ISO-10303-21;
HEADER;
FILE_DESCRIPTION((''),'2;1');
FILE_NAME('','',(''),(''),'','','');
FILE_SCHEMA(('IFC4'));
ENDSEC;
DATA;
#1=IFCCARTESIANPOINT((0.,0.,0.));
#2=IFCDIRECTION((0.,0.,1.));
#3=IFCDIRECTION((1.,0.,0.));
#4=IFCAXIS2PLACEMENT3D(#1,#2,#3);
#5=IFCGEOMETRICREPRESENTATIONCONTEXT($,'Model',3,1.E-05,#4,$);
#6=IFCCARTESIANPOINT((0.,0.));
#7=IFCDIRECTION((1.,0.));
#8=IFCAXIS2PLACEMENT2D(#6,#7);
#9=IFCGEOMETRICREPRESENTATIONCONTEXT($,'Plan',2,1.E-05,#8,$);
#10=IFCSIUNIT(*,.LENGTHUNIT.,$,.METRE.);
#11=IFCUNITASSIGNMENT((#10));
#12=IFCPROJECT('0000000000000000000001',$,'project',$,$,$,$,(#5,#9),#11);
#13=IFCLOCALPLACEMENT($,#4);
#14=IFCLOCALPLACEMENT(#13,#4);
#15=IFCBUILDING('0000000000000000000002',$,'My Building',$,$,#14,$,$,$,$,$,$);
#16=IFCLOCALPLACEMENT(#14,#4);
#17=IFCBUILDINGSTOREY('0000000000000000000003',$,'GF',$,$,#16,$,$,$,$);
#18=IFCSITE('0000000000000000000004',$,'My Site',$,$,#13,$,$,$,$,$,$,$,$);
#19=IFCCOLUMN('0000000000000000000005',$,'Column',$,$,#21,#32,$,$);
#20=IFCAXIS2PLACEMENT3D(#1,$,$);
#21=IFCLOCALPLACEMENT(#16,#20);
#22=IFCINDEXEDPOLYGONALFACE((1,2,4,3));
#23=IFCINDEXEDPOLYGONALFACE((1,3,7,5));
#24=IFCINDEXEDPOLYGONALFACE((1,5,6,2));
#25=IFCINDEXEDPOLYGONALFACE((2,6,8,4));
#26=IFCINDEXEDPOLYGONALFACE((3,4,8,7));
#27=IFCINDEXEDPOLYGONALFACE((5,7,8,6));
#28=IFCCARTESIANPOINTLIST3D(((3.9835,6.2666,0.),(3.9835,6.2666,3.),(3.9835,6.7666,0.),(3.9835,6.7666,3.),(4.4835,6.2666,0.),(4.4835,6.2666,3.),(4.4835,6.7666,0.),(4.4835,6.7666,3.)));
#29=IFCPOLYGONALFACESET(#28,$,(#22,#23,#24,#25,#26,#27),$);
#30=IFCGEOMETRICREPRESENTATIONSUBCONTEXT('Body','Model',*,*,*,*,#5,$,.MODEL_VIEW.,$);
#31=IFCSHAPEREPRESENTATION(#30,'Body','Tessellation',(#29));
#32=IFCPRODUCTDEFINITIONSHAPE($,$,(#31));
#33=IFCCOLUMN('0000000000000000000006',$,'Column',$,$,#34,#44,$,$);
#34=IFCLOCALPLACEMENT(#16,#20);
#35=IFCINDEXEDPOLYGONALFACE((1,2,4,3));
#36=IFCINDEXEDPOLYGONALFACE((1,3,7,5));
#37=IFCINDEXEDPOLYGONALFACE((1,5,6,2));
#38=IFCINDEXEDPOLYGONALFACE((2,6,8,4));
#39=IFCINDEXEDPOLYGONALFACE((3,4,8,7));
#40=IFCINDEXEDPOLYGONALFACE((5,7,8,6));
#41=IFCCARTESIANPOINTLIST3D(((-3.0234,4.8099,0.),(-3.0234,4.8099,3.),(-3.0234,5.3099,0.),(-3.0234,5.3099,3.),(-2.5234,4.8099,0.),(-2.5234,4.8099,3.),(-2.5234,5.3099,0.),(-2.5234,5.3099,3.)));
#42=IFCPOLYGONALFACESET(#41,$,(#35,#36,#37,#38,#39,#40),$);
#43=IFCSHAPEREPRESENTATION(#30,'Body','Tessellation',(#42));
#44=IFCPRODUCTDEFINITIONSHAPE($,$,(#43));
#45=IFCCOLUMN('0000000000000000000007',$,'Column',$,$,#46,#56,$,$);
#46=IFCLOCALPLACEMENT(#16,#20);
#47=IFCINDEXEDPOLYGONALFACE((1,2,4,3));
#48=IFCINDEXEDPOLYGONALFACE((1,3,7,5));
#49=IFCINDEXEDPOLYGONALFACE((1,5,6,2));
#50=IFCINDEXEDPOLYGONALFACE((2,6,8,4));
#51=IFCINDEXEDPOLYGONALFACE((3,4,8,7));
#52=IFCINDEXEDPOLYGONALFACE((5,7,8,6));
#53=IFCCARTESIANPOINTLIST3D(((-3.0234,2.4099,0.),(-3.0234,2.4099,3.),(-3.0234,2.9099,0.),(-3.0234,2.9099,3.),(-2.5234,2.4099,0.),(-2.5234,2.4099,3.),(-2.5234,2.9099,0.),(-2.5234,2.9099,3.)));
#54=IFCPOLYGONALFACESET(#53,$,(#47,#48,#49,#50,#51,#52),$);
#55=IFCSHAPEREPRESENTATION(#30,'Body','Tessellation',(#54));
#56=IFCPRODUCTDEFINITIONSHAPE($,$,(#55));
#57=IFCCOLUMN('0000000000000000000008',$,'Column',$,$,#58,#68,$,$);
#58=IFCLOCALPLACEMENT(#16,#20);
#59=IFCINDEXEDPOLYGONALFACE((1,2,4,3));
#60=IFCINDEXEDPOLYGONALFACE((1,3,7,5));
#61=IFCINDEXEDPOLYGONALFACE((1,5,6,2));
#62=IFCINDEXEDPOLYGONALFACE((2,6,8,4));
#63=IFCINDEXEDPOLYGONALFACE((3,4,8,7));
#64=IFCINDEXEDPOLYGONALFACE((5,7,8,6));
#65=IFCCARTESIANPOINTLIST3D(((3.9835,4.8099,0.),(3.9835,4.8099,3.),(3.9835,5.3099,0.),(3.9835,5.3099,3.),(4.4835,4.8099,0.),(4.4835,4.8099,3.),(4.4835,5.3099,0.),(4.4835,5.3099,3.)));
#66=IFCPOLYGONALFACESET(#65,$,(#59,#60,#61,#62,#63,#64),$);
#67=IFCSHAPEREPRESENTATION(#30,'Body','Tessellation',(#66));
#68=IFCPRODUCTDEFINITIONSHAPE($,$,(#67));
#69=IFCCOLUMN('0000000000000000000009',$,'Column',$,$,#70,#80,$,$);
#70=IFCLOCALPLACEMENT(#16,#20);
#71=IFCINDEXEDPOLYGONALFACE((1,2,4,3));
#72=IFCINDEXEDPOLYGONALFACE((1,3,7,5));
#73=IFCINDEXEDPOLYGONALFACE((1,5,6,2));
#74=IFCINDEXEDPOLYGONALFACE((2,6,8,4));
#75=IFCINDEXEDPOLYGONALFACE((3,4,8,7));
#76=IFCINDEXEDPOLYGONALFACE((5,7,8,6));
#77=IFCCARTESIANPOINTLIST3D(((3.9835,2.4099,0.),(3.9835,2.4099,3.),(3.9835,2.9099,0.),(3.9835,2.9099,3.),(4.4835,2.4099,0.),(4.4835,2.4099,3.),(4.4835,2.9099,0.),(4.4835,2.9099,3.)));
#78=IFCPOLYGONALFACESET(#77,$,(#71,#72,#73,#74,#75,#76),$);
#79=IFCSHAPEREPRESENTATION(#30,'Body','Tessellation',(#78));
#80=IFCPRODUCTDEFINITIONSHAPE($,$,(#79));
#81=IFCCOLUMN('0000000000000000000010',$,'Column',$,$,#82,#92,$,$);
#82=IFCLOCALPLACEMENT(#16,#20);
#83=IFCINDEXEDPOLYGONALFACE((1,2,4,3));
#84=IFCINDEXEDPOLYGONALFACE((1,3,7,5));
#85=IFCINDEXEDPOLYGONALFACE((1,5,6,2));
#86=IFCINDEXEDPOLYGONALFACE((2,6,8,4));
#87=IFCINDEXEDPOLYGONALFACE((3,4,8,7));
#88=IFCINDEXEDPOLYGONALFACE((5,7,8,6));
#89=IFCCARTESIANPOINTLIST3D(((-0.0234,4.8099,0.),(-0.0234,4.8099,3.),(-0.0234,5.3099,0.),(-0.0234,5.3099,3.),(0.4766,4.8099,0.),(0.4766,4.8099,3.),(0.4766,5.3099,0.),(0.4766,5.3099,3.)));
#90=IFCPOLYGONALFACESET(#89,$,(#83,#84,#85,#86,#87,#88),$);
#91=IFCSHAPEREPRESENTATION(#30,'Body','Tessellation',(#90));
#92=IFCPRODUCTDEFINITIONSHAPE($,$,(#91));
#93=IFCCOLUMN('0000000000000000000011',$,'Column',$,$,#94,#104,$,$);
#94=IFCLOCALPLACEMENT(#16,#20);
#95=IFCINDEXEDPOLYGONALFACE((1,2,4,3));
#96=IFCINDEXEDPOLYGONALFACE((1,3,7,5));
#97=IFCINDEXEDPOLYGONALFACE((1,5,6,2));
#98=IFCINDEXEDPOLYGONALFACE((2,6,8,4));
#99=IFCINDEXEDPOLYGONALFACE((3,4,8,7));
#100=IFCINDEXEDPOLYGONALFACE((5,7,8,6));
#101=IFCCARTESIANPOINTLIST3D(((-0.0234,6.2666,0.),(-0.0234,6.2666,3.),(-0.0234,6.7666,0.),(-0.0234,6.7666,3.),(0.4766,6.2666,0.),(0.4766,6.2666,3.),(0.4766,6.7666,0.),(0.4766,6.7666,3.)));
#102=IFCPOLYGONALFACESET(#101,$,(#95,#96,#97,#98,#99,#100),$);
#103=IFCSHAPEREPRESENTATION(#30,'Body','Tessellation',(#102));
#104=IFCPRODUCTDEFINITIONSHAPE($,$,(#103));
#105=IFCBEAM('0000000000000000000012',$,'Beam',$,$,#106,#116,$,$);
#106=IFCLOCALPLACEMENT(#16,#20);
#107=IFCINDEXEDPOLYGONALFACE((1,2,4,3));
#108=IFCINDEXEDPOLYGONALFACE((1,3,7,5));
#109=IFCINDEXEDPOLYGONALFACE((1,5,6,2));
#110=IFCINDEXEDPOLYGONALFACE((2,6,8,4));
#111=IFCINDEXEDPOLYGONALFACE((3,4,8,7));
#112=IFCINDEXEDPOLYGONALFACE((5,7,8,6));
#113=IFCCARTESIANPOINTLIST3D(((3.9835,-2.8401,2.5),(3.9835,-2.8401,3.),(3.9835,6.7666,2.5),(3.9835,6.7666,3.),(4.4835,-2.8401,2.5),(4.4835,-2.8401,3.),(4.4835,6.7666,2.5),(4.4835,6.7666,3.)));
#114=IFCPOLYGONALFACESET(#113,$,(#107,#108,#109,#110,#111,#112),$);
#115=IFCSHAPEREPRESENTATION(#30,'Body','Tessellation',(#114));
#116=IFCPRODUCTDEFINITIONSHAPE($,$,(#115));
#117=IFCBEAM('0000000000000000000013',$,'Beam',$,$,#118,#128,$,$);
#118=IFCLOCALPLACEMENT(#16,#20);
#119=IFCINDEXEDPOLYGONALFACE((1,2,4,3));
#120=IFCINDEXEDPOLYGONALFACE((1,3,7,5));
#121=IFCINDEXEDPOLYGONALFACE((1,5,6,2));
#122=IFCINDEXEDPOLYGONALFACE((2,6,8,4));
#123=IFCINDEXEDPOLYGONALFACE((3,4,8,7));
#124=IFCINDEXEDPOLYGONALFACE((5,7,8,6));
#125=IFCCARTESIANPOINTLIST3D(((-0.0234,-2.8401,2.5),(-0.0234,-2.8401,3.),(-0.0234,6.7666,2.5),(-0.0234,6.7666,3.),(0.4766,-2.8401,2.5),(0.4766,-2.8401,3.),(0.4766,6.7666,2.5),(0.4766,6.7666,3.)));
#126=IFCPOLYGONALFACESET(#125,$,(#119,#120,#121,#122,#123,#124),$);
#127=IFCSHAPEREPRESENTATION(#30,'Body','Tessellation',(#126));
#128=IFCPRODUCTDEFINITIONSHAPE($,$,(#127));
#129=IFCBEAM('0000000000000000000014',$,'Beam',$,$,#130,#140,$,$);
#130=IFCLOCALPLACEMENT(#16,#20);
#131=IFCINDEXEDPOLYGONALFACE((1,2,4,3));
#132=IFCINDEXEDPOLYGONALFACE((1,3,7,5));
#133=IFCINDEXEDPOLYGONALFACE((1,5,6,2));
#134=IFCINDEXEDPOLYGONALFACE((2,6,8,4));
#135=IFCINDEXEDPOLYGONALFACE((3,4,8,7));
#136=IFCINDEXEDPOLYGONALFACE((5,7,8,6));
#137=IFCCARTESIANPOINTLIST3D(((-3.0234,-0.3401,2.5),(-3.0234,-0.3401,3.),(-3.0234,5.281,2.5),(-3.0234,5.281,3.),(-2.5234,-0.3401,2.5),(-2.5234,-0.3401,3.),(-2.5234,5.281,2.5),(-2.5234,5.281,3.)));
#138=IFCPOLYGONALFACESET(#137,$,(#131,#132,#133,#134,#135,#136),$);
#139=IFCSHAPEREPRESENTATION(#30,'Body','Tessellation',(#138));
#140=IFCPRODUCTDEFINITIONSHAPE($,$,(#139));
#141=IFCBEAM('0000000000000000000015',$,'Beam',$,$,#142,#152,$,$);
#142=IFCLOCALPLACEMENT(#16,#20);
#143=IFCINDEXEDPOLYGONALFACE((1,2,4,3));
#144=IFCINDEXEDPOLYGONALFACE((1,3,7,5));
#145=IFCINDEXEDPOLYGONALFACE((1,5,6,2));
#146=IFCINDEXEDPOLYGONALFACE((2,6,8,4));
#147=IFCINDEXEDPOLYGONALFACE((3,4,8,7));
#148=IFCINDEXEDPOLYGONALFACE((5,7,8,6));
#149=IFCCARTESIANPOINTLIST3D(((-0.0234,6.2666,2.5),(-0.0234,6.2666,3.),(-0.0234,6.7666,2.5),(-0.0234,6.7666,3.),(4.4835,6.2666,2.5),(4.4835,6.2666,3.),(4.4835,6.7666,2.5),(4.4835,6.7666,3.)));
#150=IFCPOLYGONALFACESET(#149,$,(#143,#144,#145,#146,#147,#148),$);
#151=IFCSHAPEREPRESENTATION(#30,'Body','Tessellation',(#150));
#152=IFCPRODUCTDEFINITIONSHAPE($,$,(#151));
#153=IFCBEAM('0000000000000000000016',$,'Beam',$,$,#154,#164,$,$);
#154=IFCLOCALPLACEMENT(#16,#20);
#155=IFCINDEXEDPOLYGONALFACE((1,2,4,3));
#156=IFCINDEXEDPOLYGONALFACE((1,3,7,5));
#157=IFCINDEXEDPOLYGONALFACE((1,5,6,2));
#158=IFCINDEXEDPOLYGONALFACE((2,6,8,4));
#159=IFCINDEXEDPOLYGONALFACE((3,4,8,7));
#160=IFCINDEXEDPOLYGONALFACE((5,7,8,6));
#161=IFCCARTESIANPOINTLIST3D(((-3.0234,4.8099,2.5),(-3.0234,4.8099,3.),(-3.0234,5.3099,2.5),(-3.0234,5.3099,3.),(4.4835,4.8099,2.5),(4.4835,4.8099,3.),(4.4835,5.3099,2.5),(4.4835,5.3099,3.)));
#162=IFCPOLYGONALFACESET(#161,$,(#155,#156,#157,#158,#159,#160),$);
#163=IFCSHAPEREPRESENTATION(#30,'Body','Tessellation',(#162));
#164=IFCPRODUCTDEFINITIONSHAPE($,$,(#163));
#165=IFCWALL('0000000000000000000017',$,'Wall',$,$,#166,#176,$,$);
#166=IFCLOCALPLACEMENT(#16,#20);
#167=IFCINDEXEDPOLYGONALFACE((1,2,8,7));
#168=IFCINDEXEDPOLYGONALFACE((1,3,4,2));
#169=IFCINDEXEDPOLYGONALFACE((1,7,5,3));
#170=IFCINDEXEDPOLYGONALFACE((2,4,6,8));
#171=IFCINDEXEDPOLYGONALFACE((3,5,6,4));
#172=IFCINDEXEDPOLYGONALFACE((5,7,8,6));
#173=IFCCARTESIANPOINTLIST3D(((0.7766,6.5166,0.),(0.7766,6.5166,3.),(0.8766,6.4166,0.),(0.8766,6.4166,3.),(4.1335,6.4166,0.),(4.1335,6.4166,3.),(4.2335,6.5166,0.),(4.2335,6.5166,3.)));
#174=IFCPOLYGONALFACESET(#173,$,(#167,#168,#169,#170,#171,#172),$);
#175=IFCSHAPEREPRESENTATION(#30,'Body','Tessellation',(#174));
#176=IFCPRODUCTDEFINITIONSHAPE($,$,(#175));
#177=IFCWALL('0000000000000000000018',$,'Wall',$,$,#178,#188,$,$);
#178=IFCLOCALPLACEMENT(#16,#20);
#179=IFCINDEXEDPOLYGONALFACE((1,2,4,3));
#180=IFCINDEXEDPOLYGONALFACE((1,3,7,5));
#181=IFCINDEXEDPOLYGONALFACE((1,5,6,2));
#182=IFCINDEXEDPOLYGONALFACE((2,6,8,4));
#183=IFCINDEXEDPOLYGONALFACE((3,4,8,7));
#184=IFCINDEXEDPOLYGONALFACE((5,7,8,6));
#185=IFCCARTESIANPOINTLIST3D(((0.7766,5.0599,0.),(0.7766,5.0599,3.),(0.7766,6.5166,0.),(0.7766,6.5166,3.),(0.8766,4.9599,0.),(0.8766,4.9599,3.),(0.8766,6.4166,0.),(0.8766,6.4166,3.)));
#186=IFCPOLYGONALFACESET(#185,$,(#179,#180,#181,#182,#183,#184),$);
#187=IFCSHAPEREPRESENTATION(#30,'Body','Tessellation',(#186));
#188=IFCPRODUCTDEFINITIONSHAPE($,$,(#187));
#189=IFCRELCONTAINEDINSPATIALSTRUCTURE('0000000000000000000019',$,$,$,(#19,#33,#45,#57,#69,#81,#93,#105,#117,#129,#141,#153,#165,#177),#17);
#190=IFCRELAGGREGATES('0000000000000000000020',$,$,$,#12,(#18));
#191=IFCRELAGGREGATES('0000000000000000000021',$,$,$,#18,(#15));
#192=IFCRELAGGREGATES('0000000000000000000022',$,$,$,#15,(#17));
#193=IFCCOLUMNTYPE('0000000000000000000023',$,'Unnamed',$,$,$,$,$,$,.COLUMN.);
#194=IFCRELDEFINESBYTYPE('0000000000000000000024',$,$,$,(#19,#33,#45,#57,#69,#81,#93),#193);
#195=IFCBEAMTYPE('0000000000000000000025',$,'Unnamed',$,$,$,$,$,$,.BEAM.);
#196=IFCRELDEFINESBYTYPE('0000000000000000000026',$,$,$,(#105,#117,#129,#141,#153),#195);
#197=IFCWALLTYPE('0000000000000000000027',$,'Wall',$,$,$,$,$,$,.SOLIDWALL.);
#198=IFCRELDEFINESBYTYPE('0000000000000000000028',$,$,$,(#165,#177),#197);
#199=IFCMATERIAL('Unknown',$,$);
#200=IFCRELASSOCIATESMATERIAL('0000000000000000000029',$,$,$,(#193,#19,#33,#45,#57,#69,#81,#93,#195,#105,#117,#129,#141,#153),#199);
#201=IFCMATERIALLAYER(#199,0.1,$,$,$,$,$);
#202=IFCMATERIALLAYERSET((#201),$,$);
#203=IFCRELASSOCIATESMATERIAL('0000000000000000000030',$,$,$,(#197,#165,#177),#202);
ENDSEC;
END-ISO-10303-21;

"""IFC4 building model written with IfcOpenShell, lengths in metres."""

from ifc_helpers import new_model, si_unit, frame, origin_with_axes, origin_2d_with_axis, place, context, subcontext, project, spatial, line, indexed_curve, rectangle, outline, extrude, material, layer, layer_set, layer_usage, material_profile, profile_set, profile_usage, type_object, element, save


model = new_model("IFC4")

# Units and contexts
model_context = context("Model", 3, precision=1e-05, world=origin_with_axes())
plan_context = context("Plan", 2, precision=1e-05, world=origin_2d_with_axis())
body_context_1 = subcontext(model_context, "Body", "Model", "MODEL_VIEW")
ifc_project = project(units=[si_unit("LENGTHUNIT", "METRE")], contexts=[model_context, plan_context])

# Site, building, storey
site_placement = place(None, origin_with_axes())
site = spatial("IfcSite", under=ifc_project, at=site_placement, Name="My Site")
building_placement = place(site_placement, origin_with_axes())
building = spatial("IfcBuilding", under=site, at=building_placement, Name="My Building")
storey_placement = place(building_placement, origin_with_axes())
storey = spatial("IfcBuildingStorey", under=building, at=storey_placement, Name="GF")

# Columns
ifc_material_1 = material(Name="Unknown")
ifc_material_profile_1 = material_profile(ifc_material_1, rectangle(XDim=0.5, YDim=0.5))
ifc_profile_set_1 = profile_set([ifc_material_profile_1])
ifc_profile_usage_1 = profile_usage(ifc_profile_set_1, cardinal=5)
column_type = type_object("IfcColumnType", Name="Unnamed", PredefinedType="COLUMN", material=ifc_profile_set_1)
column_1_placement = place(storey_placement, frame((4.2335, 6.5166, 0.0), z_axis=(0.0, 0.0, 1.0), x_axis=(1.0, 0.0, 0.0)))
element("IfcColumn", 1, at=column_1_placement, inside=storey, type_object=column_type, material=ifc_profile_usage_1, Name="Column", context=body_context_1, shape_type="SweptSolid", body=[
    extrude(rectangle(XDim=0.5, YDim=0.5), origin_with_axes(), (0.0, 0.0, 1.0), 3.0),
])
ifc_profile_usage_2 = profile_usage(ifc_profile_set_1, cardinal=5)
column_2_placement = place(storey_placement, frame((-2.7734, 5.0599, 0.0), z_axis=(0.0, 0.0, 1.0), x_axis=(1.0, 0.0, 0.0)))
element("IfcColumn", 2, at=column_2_placement, inside=storey, type_object=column_type, material=ifc_profile_usage_2, Name="Column", context=body_context_1, shape_type="SweptSolid", body=[
    extrude(rectangle(XDim=0.5, YDim=0.5), origin_with_axes(), (0.0, 0.0, 1.0), 3.0),
])
ifc_profile_usage_3 = profile_usage(ifc_profile_set_1, cardinal=5)
column_3_placement = place(storey_placement, frame((-2.7734, 2.6599, 0.0), z_axis=(0.0, 0.0, 1.0), x_axis=(1.0, 0.0, 0.0)))
element("IfcColumn", 3, at=column_3_placement, inside=storey, type_object=column_type, material=ifc_profile_usage_3, Name="Column", context=body_context_1, shape_type="SweptSolid", body=[
    extrude(rectangle(XDim=0.5, YDim=0.5), origin_with_axes(), (0.0, 0.0, 1.0), 3.0),
])
ifc_profile_usage_4 = profile_usage(ifc_profile_set_1, cardinal=5)
column_4_placement = place(storey_placement, frame((4.2335, 5.0599, 0.0), z_axis=(0.0, 0.0, 1.0), x_axis=(1.0, 0.0, 0.0)))
element("IfcColumn", 4, at=column_4_placement, inside=storey, type_object=column_type, material=ifc_profile_usage_4, Name="Column", context=body_context_1, shape_type="SweptSolid", body=[
    extrude(rectangle(XDim=0.5, YDim=0.5), origin_with_axes(), (0.0, 0.0, 1.0), 3.0),
])
ifc_profile_usage_5 = profile_usage(ifc_profile_set_1, cardinal=5)
column_5_placement = place(storey_placement, frame((4.2335, 2.6599, 0.0), z_axis=(0.0, 0.0, 1.0), x_axis=(1.0, 0.0, 0.0)))
element("IfcColumn", 5, at=column_5_placement, inside=storey, type_object=column_type, material=ifc_profile_usage_5, Name="Column", context=body_context_1, shape_type="SweptSolid", body=[
    extrude(rectangle(XDim=0.5, YDim=0.5), origin_with_axes(), (0.0, 0.0, 1.0), 3.0),
])
ifc_profile_usage_6 = profile_usage(ifc_profile_set_1, cardinal=5)
column_6_placement = place(storey_placement, frame((0.2266, 5.0599, 0.0), z_axis=(0.0, 0.0, 1.0), x_axis=(1.0, 0.0, 0.0)))
element("IfcColumn", 6, at=column_6_placement, inside=storey, type_object=column_type, material=ifc_profile_usage_6, Name="Column", context=body_context_1, shape_type="SweptSolid", body=[
    extrude(rectangle(XDim=0.5, YDim=0.5), origin_with_axes(), (0.0, 0.0, 1.0), 3.0),
])
ifc_profile_usage_7 = profile_usage(ifc_profile_set_1, cardinal=5)
column_7_placement = place(storey_placement, frame((0.2266, 6.5166, 0.0), z_axis=(0.0, 0.0, 1.0), x_axis=(1.0, 0.0, 0.0)))
element("IfcColumn", 7, at=column_7_placement, inside=storey, type_object=column_type, material=ifc_profile_usage_7, Name="Column", context=body_context_1, shape_type="SweptSolid", body=[
    extrude(rectangle(XDim=0.5, YDim=0.5), origin_with_axes(), (0.0, 0.0, 1.0), 3.0),
])

# Beams
ifc_material_profile_2 = material_profile(ifc_material_1, rectangle(XDim=0.5, YDim=0.5))
ifc_profile_set_2 = profile_set([ifc_material_profile_2])
ifc_profile_usage_8 = profile_usage(ifc_profile_set_2, cardinal=7)
beam_type = type_object("IfcBeamType", Name="Unnamed", PredefinedType="BEAM", material=ifc_profile_set_2)
beam_1_placement = place(storey_placement, frame((4.4835, 6.7666, 3.0), z_axis=(0.0, -1.0, 0.0), x_axis=(1.0, 0.0, 0.0)))
element("IfcBeam", 8, at=beam_1_placement, inside=storey, type_object=beam_type, material=ifc_profile_usage_8, Name="Beam", context=body_context_1, shape_type="SweptSolid", body=[
    extrude(rectangle(XDim=0.5, YDim=0.5), frame((-0.25, -0.25, 0.0), z_axis=(0.0, 0.0, 1.0), x_axis=(1.0, 0.0, 0.0)), (0.0, 0.0, 1.0), 9.6067),
])
ifc_profile_usage_9 = profile_usage(ifc_profile_set_2, cardinal=7)
beam_2_placement = place(storey_placement, frame((0.4766, 6.7666, 3.0), z_axis=(0.0, -1.0, 0.0), x_axis=(1.0, 0.0, 0.0)))
element("IfcBeam", 9, at=beam_2_placement, inside=storey, type_object=beam_type, material=ifc_profile_usage_9, Name="Beam", context=body_context_1, shape_type="SweptSolid", body=[
    extrude(rectangle(XDim=0.5, YDim=0.5), frame((-0.25, -0.25, 0.0), z_axis=(0.0, 0.0, 1.0), x_axis=(1.0, 0.0, 0.0)), (0.0, 0.0, 1.0), 9.6067),
])
ifc_profile_usage_10 = profile_usage(ifc_profile_set_2, cardinal=7)
beam_3_placement = place(storey_placement, frame((-2.5234, 5.281, 3.0), z_axis=(0.0, -1.0, 0.0), x_axis=(1.0, 0.0, 0.0)))
element("IfcBeam", 10, at=beam_3_placement, inside=storey, type_object=beam_type, material=ifc_profile_usage_10, Name="Beam", context=body_context_1, shape_type="SweptSolid", body=[
    extrude(rectangle(XDim=0.5, YDim=0.5), frame((-0.25, -0.25, 0.0), z_axis=(0.0, 0.0, 1.0), x_axis=(1.0, 0.0, 0.0)), (0.0, 0.0, 1.0), 5.6211),
])
ifc_profile_usage_11 = profile_usage(ifc_profile_set_2, cardinal=7)
beam_4_placement = place(storey_placement, frame((-0.0234, 6.7666, 3.0), z_axis=(1.0, 0.0, 0.0), x_axis=(0.0, 1.0, 0.0)))
element("IfcBeam", 11, at=beam_4_placement, inside=storey, type_object=beam_type, material=ifc_profile_usage_11, Name="Beam", context=body_context_1, shape_type="SweptSolid", body=[
    extrude(rectangle(XDim=0.5, YDim=0.5), frame((-0.25, -0.25, 0.0), z_axis=(0.0, 0.0, 1.0), x_axis=(1.0, 0.0, 0.0)), (0.0, 0.0, 1.0), 4.5069),
])
ifc_profile_usage_12 = profile_usage(ifc_profile_set_2, cardinal=7)
beam_5_placement = place(storey_placement, frame((-3.0234, 5.3099, 3.0), z_axis=(1.0, 0.0, 0.0), x_axis=(0.0, 1.0, 0.0)))
element("IfcBeam", 12, at=beam_5_placement, inside=storey, type_object=beam_type, material=ifc_profile_usage_12, Name="Beam", context=body_context_1, shape_type="SweptSolid", body=[
    extrude(rectangle(XDim=0.5, YDim=0.5), frame((-0.25, -0.25, 0.0), z_axis=(0.0, 0.0, 1.0), x_axis=(1.0, 0.0, 0.0)), (0.0, 0.0, 1.0), 7.5069),
])

# Walls
ifc_layer_1 = layer(ifc_material_1, 0.1)
ifc_layer_set_1 = layer_set([ifc_layer_1])
ifc_layer_usage_1 = layer_usage(ifc_layer_set_1, "AXIS2", "POSITIVE", 0.0)
wall_type = type_object("IfcWallType", Name="Wall", PredefinedType="SOLIDWALL", material=ifc_layer_set_1)
wall_1_placement = place(storey_placement, frame((4.2335, 6.5166, 0.0), z_axis=(0.0, 0.0, 1.0), x_axis=(-1.0, 0.0, 0.0)))
element("IfcWall", 13, at=wall_1_placement, inside=storey, type_object=wall_type, material=ifc_layer_usage_1, Name="Wall", context=body_context_1, shape_type="SweptSolid", body=[
    extrude(outline(indexed_curve([(0.0, 0.0), (0.1, 0.1), (3.3569, 0.1), (3.4569, 0.0)], segments=[line(1, 2, 3, 4, 1)])), origin_with_axes(), (0.0, 0.0, 1.0), 3.0),
])
ifc_layer_usage_2 = layer_usage(ifc_layer_set_1, "AXIS2", "POSITIVE", 0.0)
wall_2_placement = place(storey_placement, frame((0.7766, 6.5166, 0.0), z_axis=(0.0, 0.0, 1.0), x_axis=(0.0, -1.0, 0.0)))
element("IfcWall", 14, at=wall_2_placement, inside=storey, type_object=wall_type, material=ifc_layer_usage_2, Name="Wall", context=body_context_1, shape_type="SweptSolid", body=[
    extrude(outline(indexed_curve([(0.0, 0.0), (0.1, 0.1), (1.5567, 0.1), (1.4567, 0.0)], segments=[line(1, 2, 3, 4, 1)])), origin_with_axes(), (0.0, 0.0, 1.0), 3.0),
])

save(model, "model.ifc")
